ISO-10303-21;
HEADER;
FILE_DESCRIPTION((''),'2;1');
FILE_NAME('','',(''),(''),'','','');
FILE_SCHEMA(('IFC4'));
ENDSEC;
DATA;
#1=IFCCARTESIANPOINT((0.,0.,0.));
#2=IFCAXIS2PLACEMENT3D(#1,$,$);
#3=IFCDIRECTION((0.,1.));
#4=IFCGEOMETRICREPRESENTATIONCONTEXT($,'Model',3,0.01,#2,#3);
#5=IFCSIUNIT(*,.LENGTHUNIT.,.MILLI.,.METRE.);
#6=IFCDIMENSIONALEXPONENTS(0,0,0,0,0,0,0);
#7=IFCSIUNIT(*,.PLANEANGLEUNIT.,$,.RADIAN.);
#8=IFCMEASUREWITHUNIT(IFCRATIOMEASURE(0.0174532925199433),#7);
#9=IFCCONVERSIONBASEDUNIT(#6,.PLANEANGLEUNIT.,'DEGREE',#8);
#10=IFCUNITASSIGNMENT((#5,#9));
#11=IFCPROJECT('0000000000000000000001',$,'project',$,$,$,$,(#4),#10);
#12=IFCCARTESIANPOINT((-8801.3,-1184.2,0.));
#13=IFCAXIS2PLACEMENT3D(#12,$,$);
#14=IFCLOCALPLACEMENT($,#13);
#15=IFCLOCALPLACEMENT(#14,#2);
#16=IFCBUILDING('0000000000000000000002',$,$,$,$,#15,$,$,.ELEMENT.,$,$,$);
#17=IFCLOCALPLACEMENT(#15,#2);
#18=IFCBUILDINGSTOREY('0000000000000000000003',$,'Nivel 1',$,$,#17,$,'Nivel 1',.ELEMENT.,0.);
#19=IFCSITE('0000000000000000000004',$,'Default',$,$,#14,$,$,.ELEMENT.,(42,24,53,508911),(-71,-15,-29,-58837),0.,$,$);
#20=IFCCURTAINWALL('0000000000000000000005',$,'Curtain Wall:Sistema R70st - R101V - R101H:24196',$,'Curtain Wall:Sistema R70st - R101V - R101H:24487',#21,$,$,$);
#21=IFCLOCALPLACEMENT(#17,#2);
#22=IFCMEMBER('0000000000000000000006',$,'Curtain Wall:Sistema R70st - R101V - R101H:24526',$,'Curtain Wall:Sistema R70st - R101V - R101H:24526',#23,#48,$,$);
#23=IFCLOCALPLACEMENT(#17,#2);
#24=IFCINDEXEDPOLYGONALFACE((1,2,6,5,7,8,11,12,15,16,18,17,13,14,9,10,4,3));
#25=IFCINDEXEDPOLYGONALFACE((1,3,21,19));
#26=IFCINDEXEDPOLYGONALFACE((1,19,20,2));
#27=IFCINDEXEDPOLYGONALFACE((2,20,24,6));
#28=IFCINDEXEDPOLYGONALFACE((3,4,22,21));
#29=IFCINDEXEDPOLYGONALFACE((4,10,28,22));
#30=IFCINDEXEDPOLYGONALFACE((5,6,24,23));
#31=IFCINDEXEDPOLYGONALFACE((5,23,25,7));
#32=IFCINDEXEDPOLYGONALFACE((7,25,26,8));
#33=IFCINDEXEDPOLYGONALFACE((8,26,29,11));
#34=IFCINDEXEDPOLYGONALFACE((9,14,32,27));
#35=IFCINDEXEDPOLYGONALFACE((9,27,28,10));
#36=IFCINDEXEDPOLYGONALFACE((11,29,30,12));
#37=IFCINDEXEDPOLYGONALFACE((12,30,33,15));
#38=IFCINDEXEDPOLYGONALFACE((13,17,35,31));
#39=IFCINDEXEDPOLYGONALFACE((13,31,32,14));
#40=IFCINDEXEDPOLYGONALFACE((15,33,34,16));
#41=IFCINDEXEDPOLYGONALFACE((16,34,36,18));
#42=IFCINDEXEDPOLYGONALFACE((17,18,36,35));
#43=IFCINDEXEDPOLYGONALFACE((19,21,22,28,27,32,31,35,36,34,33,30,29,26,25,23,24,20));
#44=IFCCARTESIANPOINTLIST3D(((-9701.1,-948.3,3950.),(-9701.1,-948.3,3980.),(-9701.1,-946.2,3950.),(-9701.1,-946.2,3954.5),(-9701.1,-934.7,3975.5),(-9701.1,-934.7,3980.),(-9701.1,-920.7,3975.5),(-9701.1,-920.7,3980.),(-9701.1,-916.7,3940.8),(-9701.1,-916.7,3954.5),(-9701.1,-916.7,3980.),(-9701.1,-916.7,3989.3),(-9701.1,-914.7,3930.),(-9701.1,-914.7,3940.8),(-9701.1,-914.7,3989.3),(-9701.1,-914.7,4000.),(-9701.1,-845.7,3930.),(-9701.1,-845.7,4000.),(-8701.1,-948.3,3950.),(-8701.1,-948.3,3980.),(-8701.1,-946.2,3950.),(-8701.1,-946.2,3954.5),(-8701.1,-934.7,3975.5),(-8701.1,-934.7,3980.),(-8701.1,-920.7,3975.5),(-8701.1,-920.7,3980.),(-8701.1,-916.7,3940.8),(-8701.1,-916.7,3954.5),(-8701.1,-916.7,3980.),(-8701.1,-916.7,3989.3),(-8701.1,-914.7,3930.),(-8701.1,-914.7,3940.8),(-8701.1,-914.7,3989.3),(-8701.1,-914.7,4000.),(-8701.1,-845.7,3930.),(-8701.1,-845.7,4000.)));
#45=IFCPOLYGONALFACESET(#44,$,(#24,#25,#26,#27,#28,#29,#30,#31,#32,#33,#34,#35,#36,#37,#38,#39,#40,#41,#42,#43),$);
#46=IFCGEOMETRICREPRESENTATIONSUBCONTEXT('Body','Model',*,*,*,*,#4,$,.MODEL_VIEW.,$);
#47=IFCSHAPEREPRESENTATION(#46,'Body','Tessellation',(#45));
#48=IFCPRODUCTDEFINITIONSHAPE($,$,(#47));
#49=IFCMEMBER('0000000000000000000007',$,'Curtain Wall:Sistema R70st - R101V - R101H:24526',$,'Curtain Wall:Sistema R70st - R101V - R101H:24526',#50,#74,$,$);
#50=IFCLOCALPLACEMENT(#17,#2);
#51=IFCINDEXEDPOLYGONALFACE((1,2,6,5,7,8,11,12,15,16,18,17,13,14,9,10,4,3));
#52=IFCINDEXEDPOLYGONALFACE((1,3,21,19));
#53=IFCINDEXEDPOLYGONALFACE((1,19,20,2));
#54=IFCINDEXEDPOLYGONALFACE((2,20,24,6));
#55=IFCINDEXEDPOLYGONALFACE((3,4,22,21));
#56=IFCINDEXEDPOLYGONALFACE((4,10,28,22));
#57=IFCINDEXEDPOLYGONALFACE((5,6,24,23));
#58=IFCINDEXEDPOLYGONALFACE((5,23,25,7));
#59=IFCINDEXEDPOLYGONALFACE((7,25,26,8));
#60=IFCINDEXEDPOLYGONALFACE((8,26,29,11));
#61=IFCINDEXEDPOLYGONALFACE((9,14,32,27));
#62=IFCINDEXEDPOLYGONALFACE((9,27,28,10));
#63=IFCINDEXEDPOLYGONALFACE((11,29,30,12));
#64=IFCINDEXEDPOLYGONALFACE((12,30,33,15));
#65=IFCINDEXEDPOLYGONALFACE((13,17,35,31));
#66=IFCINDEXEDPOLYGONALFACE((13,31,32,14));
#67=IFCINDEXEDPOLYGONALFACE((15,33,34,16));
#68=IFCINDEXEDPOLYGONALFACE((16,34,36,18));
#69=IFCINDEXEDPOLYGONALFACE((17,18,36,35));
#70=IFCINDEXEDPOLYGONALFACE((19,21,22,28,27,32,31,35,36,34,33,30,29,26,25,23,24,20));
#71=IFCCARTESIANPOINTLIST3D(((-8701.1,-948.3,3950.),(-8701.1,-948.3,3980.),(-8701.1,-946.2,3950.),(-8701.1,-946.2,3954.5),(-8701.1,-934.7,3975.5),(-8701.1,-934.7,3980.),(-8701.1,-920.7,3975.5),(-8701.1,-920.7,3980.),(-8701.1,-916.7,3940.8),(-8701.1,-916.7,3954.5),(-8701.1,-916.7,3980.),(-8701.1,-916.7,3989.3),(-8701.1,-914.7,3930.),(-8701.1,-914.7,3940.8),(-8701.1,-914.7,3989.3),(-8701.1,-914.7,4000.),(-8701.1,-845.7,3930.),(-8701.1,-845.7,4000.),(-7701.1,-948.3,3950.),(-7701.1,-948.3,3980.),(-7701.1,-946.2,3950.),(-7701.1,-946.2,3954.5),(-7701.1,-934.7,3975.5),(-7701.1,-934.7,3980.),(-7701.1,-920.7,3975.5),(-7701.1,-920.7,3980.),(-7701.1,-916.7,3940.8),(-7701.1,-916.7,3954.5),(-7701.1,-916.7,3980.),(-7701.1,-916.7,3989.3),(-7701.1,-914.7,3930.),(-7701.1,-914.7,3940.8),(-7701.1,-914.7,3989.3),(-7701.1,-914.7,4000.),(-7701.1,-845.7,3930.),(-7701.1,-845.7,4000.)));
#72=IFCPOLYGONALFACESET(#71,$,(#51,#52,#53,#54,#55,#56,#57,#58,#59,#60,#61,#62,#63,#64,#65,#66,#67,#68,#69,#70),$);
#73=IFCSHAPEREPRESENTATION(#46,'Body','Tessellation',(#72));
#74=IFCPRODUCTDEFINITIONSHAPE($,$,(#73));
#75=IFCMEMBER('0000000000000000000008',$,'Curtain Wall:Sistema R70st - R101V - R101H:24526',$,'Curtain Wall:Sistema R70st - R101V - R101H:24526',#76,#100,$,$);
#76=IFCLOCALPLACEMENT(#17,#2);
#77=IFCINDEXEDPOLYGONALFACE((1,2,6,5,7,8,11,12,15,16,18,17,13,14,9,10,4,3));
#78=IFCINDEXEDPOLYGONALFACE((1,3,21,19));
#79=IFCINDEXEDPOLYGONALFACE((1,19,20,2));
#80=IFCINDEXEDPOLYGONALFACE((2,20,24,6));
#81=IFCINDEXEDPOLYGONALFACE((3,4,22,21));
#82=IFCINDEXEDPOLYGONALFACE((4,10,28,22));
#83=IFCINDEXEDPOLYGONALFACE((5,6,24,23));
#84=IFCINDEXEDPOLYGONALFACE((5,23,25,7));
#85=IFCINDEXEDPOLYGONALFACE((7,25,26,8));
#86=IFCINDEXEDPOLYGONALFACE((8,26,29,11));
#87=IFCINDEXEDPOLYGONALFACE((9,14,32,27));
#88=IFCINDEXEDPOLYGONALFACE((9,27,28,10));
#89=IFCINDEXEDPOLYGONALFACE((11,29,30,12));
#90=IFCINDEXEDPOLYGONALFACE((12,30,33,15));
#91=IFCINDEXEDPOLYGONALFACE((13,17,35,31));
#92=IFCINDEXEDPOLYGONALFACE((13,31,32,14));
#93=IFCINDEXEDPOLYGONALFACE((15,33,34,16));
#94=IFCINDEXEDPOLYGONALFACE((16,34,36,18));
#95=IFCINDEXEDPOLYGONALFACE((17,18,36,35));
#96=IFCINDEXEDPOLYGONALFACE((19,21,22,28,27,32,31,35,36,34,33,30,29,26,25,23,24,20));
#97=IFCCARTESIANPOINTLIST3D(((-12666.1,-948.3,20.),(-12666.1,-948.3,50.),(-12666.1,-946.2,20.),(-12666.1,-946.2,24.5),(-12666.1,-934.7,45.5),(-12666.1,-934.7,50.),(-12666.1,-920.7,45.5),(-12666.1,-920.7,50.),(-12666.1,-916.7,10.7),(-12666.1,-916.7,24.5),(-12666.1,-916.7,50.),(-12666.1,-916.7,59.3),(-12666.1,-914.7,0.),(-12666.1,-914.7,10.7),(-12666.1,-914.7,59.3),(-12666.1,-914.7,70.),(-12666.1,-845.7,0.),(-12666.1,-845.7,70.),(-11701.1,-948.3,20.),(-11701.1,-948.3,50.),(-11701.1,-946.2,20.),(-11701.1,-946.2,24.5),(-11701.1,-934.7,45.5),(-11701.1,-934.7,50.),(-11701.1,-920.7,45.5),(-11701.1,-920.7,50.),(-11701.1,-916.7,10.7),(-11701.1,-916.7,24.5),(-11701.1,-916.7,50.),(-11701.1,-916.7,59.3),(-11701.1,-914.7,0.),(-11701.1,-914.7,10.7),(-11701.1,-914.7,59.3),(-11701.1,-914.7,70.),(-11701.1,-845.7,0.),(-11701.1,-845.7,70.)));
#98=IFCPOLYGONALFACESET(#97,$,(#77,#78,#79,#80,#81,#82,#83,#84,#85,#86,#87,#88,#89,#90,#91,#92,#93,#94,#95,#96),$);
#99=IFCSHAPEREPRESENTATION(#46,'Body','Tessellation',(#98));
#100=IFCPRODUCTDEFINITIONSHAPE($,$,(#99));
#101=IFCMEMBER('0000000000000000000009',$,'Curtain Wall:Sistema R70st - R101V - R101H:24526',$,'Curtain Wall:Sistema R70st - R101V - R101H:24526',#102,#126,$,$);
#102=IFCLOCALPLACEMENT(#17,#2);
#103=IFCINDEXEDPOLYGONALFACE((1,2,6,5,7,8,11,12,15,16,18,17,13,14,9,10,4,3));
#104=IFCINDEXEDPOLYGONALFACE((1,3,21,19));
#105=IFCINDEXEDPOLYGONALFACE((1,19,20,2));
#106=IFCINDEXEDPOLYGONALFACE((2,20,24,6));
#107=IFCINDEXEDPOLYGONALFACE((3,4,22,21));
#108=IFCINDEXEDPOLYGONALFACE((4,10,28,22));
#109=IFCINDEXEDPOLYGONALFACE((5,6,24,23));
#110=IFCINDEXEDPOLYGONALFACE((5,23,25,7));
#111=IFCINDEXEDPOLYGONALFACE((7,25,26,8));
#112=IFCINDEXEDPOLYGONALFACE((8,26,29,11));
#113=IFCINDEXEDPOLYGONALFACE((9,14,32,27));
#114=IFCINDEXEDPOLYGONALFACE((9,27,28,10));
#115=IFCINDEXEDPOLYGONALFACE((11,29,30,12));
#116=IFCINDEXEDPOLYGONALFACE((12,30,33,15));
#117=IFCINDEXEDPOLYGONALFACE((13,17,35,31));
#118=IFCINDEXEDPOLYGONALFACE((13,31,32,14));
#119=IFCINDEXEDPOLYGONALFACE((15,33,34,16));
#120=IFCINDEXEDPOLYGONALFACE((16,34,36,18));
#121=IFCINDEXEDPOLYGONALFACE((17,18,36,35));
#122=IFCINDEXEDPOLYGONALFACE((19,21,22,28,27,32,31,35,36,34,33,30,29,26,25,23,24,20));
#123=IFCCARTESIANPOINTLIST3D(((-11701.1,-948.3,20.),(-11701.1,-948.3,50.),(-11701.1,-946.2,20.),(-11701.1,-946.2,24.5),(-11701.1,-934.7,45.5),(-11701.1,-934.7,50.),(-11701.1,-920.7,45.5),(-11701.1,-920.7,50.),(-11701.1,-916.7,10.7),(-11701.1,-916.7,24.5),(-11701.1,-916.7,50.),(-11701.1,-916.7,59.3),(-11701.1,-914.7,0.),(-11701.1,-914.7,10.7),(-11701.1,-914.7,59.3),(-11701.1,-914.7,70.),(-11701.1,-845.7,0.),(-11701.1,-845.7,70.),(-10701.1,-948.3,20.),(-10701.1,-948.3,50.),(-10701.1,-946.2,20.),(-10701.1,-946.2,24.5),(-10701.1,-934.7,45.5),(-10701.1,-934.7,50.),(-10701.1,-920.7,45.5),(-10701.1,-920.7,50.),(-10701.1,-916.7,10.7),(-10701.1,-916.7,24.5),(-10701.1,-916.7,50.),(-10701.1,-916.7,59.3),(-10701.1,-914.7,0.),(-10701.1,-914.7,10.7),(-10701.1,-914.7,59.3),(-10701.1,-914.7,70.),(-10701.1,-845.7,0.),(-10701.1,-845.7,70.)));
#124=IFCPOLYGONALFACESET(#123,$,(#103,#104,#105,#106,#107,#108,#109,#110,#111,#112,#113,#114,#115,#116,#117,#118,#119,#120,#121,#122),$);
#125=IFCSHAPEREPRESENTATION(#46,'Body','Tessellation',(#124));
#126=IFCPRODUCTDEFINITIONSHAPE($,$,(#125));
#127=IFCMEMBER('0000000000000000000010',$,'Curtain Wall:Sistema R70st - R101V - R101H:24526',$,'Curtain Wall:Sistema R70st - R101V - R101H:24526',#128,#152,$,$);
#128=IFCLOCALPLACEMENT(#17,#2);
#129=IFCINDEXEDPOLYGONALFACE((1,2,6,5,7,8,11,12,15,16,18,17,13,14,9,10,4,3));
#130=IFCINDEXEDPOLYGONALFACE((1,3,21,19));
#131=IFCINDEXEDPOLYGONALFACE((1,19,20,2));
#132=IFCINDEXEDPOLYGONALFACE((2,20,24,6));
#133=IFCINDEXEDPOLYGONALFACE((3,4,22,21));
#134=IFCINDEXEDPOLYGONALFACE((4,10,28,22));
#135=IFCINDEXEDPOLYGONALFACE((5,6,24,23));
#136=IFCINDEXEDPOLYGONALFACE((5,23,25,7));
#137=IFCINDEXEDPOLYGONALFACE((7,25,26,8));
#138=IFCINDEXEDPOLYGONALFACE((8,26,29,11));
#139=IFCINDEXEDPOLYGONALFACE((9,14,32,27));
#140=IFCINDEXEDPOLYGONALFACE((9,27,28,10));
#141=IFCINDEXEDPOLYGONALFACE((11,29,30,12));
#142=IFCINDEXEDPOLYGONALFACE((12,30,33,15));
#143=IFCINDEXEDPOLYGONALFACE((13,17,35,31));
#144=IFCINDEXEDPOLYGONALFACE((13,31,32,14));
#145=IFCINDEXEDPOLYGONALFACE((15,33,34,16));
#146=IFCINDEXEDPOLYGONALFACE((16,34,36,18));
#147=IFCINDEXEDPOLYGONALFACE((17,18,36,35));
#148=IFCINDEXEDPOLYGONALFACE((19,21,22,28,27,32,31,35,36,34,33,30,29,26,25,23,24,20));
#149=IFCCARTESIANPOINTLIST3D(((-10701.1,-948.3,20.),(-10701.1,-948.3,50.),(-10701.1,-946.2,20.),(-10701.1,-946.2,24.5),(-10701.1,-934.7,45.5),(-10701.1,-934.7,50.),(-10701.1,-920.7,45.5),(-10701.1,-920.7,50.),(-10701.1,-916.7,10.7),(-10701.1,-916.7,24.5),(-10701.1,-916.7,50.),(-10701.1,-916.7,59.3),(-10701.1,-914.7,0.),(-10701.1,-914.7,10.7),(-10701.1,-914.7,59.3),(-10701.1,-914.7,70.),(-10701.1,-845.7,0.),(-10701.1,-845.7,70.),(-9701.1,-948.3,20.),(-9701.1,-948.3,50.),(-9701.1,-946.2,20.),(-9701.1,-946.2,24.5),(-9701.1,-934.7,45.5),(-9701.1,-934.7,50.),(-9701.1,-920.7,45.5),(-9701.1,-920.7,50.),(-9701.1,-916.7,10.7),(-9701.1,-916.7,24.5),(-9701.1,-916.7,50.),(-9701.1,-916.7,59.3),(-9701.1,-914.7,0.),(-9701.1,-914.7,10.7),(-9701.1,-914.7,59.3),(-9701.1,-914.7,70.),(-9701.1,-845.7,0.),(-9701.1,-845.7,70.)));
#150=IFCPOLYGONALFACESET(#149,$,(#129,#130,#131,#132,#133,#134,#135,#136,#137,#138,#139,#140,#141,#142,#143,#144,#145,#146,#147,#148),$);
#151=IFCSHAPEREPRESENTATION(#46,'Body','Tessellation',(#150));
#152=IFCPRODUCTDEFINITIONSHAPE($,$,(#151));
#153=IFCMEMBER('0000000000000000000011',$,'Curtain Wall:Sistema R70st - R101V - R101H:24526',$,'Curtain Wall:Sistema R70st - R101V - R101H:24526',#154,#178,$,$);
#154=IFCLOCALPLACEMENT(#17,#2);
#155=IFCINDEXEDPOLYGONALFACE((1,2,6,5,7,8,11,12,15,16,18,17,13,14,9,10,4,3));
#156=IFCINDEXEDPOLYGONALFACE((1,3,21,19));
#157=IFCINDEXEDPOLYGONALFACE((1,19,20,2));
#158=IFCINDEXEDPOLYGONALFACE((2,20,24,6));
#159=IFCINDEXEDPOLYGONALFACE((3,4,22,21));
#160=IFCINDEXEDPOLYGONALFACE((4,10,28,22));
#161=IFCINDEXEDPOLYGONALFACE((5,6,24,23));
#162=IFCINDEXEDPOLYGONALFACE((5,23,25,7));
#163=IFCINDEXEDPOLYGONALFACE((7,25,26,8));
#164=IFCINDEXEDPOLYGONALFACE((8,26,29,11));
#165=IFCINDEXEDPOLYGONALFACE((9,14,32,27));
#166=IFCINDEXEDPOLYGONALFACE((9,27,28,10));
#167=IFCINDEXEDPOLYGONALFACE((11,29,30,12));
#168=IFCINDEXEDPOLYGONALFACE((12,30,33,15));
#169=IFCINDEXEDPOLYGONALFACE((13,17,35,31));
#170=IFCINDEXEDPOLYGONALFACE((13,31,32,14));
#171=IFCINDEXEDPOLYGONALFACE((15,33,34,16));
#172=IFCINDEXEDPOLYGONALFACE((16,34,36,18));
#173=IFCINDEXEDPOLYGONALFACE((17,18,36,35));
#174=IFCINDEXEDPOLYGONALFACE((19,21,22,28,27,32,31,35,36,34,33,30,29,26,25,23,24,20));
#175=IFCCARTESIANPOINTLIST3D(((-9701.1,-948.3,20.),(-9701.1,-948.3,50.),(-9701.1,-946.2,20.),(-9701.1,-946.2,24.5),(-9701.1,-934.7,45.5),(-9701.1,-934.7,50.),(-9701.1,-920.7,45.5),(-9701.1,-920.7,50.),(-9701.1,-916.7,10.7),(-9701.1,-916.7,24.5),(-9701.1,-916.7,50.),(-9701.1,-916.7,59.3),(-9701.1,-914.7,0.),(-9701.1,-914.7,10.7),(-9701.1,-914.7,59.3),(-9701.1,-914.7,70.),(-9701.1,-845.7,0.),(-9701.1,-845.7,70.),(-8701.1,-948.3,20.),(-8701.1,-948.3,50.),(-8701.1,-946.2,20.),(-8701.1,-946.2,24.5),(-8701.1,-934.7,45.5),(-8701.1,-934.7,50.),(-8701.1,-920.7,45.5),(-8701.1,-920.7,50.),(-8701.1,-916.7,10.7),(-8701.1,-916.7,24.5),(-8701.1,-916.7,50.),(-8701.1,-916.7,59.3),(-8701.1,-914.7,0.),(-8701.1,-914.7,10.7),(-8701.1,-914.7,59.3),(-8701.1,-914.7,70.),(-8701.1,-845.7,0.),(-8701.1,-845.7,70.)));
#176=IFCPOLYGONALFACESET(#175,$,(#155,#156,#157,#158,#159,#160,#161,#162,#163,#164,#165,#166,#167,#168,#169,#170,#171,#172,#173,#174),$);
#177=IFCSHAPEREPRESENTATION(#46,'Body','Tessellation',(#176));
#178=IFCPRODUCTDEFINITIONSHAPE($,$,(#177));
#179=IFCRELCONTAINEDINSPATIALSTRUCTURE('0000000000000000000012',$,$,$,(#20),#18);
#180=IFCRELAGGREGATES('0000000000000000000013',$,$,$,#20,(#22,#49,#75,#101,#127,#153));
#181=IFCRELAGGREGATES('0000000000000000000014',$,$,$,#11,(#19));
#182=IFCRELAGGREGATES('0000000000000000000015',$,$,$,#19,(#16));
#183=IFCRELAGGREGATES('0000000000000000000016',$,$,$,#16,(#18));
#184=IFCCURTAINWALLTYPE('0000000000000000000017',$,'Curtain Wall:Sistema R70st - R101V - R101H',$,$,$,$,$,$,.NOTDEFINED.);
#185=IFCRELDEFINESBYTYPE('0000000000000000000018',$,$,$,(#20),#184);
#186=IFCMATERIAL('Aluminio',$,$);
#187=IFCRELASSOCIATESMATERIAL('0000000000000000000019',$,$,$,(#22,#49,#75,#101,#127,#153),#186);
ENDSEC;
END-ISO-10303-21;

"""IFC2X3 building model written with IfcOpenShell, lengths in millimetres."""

from ifc_helpers import new_model, entity, si_unit, converted_unit, direction, frame, origin, place, context, subcontext, project, spatial, polyline, outline, extrude, material, type_object, element, aggregate, save


model = new_model("IFC2X3")

# Units and contexts
model_context = context("Model", 3, precision=0.01, world=origin(), true_north=direction((0.0, 1.0)))
body_context = subcontext(model_context, "Body", "Model", "MODEL_VIEW")
ifc_project = project(units=[si_unit("LENGTHUNIT", "METRE", prefix="MILLI"), converted_unit("PLANEANGLEUNIT", "DEGREE", entity("IfcRatioMeasure", 0.0174532925199433), si_unit("PLANEANGLEUNIT", "RADIAN"), dimensions=[0, 0, 0, 0, 0, 0, 0])], contexts=[model_context])

# Site, building, storey
site_placement = place(None, frame((-8801.3, -1184.2, 0.0)))
site = spatial("IfcSite", under=ifc_project, at=site_placement, Name="Default", CompositionType="ELEMENT", RefLatitude=(42, 24, 53, 508911), RefLongitude=(-71, -15, -29, -58837), RefElevation=0.0)
building_placement = place(site_placement, origin())
building = spatial("IfcBuilding", under=site, at=building_placement, CompositionType="ELEMENT")
storey_placement = place(building_placement, origin())
storey = spatial("IfcBuildingStorey", under=building, at=storey_placement, Name="Nivel 1", LongName="Nivel 1", CompositionType="ELEMENT", Elevation=0.0)

# Curtain wall, members
curtain_wall_type = type_object("IfcCurtainWallType", Name="Curtain Wall:Sistema R70st - R101V - R101H", PredefinedType="NOTDEFINED")
curtain_wall_placement = place(storey_placement, origin())
curtain_wall = element("IfcCurtainWall", 1, at=curtain_wall_placement, inside=storey, type_object=curtain_wall_type, Name="Curtain Wall:Sistema R70st - R101V - R101H:24196", ObjectType="Curtain Wall:Sistema R70st - R101V - R101H:24487")
ifc_material = material(Name="Aluminio")
member_1_placement = place(curtain_wall_placement, origin())
member_1 = element("IfcMember", 2, at=member_1_placement, material=ifc_material, Name="Curtain Wall:Sistema R70st - R101V - R101H:24526", ObjectType="Curtain Wall:Sistema R70st - R101V - R101H:24526", context=body_context, shape_type="SweptSolid", body=[
    extrude(outline(polyline([(-33.3, -71.9), (36.7, -71.9), (36.7, -2.9), (25.9, -2.9), (25.9, -0.9), (12.2, -0.9), (12.2, 28.6), (16.7, 28.6), (16.7, 30.7), (-13.3, 30.7), (-13.3, 17.1), (-8.8, 17.1), (-8.8, 3.1), (-13.3, 3.1), (-13.3, -0.9), (-22.6, -0.9), (-22.6, -2.9), (-33.3, -2.9), (-33.3, -71.9)])), frame((-8701.1, -917.6, 3966.7), z_axis=(-1.0, 0.0, 0.0), x_axis=(0.0, 0.0, -1.0)), (0.0, 0.0, 1.0), 1000.0),
])
member_2_placement = place(curtain_wall_placement, origin())
member_2 = element("IfcMember", 3, at=member_2_placement, material=ifc_material, Name="Curtain Wall:Sistema R70st - R101V - R101H:24526", ObjectType="Curtain Wall:Sistema R70st - R101V - R101H:24526", context=body_context, shape_type="SweptSolid", body=[
    extrude(outline(polyline([(-33.3, -71.9), (36.7, -71.9), (36.7, -2.9), (25.9, -2.9), (25.9, -0.9), (12.2, -0.9), (12.2, 28.6), (16.7, 28.6), (16.7, 30.7), (-13.3, 30.7), (-13.3, 17.1), (-8.8, 17.1), (-8.8, 3.1), (-13.3, 3.1), (-13.3, -0.9), (-22.6, -0.9), (-22.6, -2.9), (-33.3, -2.9), (-33.3, -71.9)])), frame((-7701.1, -917.6, 3966.7), z_axis=(-1.0, 0.0, 0.0), x_axis=(0.0, 0.0, -1.0)), (0.0, 0.0, 1.0), 1000.0),
])
member_3_placement = place(curtain_wall_placement, origin())
member_3 = element("IfcMember", 4, at=member_3_placement, material=ifc_material, Name="Curtain Wall:Sistema R70st - R101V - R101H:24526", ObjectType="Curtain Wall:Sistema R70st - R101V - R101H:24526", context=body_context, shape_type="SweptSolid", body=[
    extrude(outline(polyline([(-13.3, -30.7), (16.7, -30.7), (16.7, -28.6), (12.2, -28.6), (12.2, 0.9), (25.9, 0.9), (25.9, 2.9), (36.7, 2.9), (36.7, 71.9), (-33.3, 71.9), (-33.3, 2.9), (-22.6, 2.9), (-22.6, 0.9), (-13.3, 0.9), (-13.3, -3.1), (-8.8, -3.1), (-8.8, -17.1), (-13.3, -17.1), (-13.3, -30.7)])), frame((-12666.1, -917.6, 36.7), z_axis=(1.0, 0.0, 0.0), x_axis=(0.0, 0.0, -1.0)), (0.0, 0.0, 1.0), 965.0),
])
member_4_placement = place(curtain_wall_placement, origin())
member_4 = element("IfcMember", 5, at=member_4_placement, material=ifc_material, Name="Curtain Wall:Sistema R70st - R101V - R101H:24526", ObjectType="Curtain Wall:Sistema R70st - R101V - R101H:24526", context=body_context, shape_type="SweptSolid", body=[
    extrude(outline(polyline([(-13.3, -30.7), (16.7, -30.7), (16.7, -28.6), (12.2, -28.6), (12.2, 0.9), (25.9, 0.9), (25.9, 2.9), (36.7, 2.9), (36.7, 71.9), (-33.3, 71.9), (-33.3, 2.9), (-22.6, 2.9), (-22.6, 0.9), (-13.3, 0.9), (-13.3, -3.1), (-8.8, -3.1), (-8.8, -17.1), (-13.3, -17.1), (-13.3, -30.7)])), frame((-11701.1, -917.6, 36.7), z_axis=(1.0, 0.0, 0.0), x_axis=(0.0, 0.0, -1.0)), (0.0, 0.0, 1.0), 1000.0),
])
member_5_placement = place(curtain_wall_placement, origin())
member_5 = element("IfcMember", 6, at=member_5_placement, material=ifc_material, Name="Curtain Wall:Sistema R70st - R101V - R101H:24526", ObjectType="Curtain Wall:Sistema R70st - R101V - R101H:24526", context=body_context, shape_type="SweptSolid", body=[
    extrude(outline(polyline([(-13.3, -30.7), (16.7, -30.7), (16.7, -28.6), (12.2, -28.6), (12.2, 0.9), (25.9, 0.9), (25.9, 2.9), (36.7, 2.9), (36.7, 71.9), (-33.3, 71.9), (-33.3, 2.9), (-22.6, 2.9), (-22.6, 0.9), (-13.3, 0.9), (-13.3, -3.1), (-8.8, -3.1), (-8.8, -17.1), (-13.3, -17.1), (-13.3, -30.7)])), frame((-10701.1, -917.6, 36.7), z_axis=(1.0, 0.0, 0.0), x_axis=(0.0, 0.0, -1.0)), (0.0, 0.0, 1.0), 1000.0),
])
member_6_placement = place(curtain_wall_placement, origin())
member_6 = element("IfcMember", 7, at=member_6_placement, material=ifc_material, Name="Curtain Wall:Sistema R70st - R101V - R101H:24526", ObjectType="Curtain Wall:Sistema R70st - R101V - R101H:24526", context=body_context, shape_type="SweptSolid", body=[
    extrude(outline(polyline([(-13.3, -30.7), (16.7, -30.7), (16.7, -28.6), (12.2, -28.6), (12.2, 0.9), (25.9, 0.9), (25.9, 2.9), (36.7, 2.9), (36.7, 71.9), (-33.3, 71.9), (-33.3, 2.9), (-22.6, 2.9), (-22.6, 0.9), (-13.3, 0.9), (-13.3, -3.1), (-8.8, -3.1), (-8.8, -17.1), (-13.3, -17.1), (-13.3, -30.7)])), frame((-9701.1, -917.6, 36.7), z_axis=(1.0, 0.0, 0.0), x_axis=(0.0, 0.0, -1.0)), (0.0, 0.0, 1.0), 1000.0),
])
aggregate(curtain_wall, [member_1, member_2, member_3, member_4, member_5, member_6])

save(model, "model.ifc")
